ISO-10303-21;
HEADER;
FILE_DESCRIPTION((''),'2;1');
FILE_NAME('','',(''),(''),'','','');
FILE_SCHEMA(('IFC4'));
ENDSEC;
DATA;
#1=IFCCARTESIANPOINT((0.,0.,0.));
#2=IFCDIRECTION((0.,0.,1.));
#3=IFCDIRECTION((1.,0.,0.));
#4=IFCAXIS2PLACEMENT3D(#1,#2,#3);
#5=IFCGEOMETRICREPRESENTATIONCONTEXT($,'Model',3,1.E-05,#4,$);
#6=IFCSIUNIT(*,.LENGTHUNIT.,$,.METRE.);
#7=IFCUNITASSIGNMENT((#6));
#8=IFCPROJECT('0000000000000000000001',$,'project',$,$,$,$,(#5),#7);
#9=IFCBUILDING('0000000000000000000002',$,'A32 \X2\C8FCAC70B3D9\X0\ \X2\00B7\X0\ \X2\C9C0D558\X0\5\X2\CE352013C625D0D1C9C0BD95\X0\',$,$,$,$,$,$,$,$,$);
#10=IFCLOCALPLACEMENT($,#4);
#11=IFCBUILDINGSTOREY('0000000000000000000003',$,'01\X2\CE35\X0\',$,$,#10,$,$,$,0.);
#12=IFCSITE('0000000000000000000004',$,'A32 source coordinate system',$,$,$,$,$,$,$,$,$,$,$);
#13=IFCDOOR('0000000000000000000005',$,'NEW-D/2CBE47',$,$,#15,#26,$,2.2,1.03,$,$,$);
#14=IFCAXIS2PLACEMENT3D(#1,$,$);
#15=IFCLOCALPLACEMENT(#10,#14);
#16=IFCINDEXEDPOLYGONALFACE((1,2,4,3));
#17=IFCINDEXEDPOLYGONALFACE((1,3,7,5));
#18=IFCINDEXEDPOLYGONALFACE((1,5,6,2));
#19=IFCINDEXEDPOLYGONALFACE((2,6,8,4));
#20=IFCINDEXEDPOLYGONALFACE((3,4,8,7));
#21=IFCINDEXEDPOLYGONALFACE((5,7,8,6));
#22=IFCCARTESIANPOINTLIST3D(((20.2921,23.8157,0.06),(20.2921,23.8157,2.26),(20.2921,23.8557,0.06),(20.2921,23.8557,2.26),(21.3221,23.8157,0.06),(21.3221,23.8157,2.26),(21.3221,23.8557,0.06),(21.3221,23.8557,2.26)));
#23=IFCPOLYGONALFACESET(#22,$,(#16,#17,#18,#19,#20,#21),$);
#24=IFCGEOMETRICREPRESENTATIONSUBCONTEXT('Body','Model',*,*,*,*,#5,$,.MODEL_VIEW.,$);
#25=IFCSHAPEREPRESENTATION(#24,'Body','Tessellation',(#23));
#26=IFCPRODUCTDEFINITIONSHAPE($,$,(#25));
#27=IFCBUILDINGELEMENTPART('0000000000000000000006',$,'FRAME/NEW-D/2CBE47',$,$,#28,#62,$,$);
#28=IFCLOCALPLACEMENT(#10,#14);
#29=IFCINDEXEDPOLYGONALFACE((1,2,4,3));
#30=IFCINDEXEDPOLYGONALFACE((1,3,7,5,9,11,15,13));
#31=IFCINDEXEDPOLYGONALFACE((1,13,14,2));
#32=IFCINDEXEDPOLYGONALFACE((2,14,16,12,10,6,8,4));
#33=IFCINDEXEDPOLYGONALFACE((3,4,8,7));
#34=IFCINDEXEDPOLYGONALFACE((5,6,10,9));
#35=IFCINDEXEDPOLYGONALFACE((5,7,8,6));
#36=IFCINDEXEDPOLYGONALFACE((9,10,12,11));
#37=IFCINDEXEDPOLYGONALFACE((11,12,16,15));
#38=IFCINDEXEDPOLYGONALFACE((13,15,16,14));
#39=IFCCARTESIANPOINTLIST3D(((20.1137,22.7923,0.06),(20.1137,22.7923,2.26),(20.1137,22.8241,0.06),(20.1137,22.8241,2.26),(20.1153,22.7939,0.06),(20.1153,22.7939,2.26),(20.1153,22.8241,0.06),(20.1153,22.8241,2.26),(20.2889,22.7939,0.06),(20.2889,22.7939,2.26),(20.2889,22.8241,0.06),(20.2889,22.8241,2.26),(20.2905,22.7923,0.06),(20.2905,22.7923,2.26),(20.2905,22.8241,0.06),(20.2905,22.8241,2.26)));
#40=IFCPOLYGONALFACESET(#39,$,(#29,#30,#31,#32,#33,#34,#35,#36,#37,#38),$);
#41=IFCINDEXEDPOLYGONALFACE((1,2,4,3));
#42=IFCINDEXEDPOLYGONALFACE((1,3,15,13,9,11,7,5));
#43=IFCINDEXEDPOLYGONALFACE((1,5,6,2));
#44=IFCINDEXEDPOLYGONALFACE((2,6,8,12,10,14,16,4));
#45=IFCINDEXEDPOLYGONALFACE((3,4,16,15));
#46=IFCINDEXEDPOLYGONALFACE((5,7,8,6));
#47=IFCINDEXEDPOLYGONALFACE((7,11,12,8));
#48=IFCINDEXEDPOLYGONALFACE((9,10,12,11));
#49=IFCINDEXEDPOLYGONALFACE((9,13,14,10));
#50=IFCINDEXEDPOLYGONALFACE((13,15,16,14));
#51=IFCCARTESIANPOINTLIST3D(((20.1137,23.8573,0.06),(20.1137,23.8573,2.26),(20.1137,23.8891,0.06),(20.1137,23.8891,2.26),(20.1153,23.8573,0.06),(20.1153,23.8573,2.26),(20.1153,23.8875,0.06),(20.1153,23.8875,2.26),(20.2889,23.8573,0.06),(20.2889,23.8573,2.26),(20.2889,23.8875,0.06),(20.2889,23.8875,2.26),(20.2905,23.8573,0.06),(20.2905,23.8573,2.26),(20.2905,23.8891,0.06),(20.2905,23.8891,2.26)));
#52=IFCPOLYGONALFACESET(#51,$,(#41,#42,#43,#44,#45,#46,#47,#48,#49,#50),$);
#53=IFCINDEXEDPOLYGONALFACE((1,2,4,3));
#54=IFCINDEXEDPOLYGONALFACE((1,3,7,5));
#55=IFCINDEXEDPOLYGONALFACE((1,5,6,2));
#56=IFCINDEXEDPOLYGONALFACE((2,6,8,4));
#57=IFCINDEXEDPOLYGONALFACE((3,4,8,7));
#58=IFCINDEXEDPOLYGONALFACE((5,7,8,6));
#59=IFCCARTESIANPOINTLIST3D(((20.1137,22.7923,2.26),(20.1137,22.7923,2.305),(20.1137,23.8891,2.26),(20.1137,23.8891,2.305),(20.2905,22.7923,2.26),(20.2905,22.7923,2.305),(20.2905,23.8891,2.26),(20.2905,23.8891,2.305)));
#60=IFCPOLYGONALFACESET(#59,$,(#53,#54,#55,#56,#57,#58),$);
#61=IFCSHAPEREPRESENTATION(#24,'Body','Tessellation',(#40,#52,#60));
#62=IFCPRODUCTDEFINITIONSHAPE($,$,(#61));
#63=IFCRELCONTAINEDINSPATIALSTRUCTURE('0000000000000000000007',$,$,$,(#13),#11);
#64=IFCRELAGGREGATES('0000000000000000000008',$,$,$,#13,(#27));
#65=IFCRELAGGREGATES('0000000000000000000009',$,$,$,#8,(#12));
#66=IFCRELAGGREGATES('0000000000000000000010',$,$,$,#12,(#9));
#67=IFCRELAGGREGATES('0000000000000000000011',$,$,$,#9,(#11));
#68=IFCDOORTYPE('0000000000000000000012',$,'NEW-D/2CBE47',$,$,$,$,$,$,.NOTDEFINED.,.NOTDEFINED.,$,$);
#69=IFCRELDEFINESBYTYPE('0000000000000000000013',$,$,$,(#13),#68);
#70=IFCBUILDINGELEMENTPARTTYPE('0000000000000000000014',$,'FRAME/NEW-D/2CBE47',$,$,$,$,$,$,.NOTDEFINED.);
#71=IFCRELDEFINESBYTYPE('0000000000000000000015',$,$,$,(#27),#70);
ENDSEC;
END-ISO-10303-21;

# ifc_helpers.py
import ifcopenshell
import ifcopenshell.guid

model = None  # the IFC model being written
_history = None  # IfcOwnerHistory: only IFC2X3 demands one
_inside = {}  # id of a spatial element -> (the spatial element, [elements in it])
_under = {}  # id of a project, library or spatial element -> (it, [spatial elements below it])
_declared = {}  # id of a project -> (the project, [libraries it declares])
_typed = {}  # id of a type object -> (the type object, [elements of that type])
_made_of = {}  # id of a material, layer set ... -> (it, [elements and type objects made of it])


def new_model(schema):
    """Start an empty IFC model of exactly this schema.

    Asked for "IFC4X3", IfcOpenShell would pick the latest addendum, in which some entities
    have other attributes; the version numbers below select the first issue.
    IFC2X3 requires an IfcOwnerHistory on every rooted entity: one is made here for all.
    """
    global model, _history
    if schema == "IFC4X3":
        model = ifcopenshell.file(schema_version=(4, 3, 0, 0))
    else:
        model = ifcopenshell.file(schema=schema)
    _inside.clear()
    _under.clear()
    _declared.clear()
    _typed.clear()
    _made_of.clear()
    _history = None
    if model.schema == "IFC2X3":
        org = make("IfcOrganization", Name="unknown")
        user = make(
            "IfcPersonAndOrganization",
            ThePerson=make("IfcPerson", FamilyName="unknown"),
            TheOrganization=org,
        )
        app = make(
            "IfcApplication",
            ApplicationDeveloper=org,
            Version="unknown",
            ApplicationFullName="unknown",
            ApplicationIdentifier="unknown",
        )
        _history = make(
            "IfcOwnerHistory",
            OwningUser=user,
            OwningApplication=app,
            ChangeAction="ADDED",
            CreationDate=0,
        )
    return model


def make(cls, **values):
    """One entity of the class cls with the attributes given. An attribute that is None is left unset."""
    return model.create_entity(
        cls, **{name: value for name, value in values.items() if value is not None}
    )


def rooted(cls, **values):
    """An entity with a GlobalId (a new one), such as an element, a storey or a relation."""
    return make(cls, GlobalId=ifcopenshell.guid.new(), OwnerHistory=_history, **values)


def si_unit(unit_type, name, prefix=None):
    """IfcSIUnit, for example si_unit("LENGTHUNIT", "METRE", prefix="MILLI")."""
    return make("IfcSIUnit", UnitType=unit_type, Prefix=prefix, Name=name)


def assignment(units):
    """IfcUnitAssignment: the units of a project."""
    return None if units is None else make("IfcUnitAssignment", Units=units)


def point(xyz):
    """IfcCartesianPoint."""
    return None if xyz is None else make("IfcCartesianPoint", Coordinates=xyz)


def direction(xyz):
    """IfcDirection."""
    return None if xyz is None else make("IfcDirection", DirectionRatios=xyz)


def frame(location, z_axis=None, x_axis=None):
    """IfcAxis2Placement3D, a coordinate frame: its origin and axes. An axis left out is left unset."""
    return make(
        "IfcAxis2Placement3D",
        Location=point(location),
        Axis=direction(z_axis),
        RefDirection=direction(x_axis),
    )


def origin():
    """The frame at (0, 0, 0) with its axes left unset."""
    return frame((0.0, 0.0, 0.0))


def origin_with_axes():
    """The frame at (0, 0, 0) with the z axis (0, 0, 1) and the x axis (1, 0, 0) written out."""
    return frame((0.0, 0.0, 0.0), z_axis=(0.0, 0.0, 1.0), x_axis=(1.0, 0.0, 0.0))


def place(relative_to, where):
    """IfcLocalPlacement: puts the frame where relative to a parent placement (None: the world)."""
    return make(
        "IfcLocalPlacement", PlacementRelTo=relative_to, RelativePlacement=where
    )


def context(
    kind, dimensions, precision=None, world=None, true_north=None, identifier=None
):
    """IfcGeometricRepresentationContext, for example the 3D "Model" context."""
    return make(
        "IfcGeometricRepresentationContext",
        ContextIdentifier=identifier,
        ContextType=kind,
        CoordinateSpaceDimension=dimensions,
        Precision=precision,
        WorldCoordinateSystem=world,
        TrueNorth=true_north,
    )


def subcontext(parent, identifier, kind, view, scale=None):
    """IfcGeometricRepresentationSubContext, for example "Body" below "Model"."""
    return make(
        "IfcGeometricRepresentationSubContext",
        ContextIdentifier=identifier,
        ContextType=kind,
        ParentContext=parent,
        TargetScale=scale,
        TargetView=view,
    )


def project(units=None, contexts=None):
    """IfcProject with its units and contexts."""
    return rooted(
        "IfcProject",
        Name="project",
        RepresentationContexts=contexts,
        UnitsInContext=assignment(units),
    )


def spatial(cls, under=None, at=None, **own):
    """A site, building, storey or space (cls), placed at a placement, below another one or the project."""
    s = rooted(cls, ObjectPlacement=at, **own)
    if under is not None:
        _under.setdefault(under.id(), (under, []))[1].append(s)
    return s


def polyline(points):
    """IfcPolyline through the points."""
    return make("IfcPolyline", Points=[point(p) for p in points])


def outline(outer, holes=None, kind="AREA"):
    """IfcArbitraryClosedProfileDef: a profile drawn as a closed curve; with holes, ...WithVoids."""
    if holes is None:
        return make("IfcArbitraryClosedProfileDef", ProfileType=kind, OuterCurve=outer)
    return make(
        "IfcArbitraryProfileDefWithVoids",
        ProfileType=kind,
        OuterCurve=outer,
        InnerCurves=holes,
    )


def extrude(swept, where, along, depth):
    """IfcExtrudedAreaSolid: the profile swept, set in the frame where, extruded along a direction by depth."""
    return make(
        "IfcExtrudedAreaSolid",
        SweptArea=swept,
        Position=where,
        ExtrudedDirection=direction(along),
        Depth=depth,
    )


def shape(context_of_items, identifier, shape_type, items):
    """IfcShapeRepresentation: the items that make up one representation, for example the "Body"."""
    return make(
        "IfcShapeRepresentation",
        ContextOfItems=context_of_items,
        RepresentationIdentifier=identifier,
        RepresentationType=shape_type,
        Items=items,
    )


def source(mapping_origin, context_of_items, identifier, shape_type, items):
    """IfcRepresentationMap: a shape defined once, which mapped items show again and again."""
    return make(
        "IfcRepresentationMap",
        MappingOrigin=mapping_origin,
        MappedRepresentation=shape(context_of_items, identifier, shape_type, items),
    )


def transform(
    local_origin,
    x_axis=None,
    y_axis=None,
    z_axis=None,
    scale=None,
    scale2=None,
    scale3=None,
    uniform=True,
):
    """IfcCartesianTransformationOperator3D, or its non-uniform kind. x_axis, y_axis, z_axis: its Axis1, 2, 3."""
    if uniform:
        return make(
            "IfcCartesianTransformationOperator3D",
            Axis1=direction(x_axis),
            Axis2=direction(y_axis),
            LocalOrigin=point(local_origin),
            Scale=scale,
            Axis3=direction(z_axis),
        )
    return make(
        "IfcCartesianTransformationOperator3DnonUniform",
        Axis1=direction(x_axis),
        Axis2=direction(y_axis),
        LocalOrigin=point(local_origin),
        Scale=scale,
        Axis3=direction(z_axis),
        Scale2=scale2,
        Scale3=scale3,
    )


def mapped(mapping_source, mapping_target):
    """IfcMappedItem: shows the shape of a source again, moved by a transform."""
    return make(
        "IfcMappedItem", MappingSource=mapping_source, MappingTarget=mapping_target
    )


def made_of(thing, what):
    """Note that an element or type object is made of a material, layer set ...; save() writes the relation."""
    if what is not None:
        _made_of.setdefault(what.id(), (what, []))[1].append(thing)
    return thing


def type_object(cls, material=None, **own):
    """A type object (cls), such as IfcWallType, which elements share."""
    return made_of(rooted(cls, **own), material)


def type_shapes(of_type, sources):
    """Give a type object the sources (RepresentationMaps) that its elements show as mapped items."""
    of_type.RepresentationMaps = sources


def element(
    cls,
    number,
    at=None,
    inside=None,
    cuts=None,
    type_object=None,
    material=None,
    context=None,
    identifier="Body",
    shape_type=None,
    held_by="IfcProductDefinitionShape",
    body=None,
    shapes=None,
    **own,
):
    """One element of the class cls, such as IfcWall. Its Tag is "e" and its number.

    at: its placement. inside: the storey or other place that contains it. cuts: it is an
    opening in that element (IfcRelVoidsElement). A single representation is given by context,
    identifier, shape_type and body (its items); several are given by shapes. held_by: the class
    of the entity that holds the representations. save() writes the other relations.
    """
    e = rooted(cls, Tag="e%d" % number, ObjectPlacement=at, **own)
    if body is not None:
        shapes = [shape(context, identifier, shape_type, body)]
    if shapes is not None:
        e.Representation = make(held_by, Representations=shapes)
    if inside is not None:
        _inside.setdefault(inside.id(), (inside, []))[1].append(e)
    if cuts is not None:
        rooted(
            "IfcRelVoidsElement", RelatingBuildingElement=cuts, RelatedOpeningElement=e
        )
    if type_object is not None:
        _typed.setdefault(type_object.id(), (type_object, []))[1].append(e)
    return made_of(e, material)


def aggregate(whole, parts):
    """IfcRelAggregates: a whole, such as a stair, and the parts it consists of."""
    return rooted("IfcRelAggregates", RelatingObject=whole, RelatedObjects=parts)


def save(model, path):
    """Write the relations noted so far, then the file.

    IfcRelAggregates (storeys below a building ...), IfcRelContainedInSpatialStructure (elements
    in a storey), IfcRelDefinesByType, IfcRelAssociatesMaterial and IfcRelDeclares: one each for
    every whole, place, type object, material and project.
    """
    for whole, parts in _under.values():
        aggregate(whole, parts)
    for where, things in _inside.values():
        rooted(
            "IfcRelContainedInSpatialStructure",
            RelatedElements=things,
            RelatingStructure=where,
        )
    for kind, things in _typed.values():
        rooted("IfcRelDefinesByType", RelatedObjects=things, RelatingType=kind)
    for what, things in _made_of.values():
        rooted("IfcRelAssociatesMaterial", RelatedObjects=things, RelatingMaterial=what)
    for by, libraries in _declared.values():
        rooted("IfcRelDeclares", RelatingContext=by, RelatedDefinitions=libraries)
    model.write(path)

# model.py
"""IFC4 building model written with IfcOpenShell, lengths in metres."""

from ifc_helpers import new_model, si_unit, frame, origin, origin_with_axes, place, context, subcontext, project, spatial, polyline, outline, extrude, source, transform, mapped, type_object, type_shapes, element, aggregate, save


model = new_model("IFC4")

# Units and contexts
model_context = context("Model", 3, precision=1e-05, world=origin_with_axes())
body_context = subcontext(model_context, "Body", "Model", "MODEL_VIEW")
ifc_project = project(units=[si_unit("LENGTHUNIT", "METRE")], contexts=[model_context])

# Site, building, storey
site = spatial("IfcSite", under=ifc_project, Name="A32 source coordinate system")
building = spatial("IfcBuilding", under=site, Name="A32 주거동 · 지하5층–옥탑지붕")
storey_placement = place(None, origin_with_axes())
storey = spatial("IfcBuildingStorey", under=building, at=storey_placement, Name="01층", Elevation=0.0)

# Door
door_type_1 = type_object("IfcDoorType", Name="NEW-D/2CBE47", OperationType="NOTDEFINED", PredefinedType="NOTDEFINED")
shared_shape_1 = source(origin(), body_context, "Body", "SweptSolid", [
    extrude(outline(polyline([(21.3221, 23.8157), (20.2921, 23.8157), (20.2921, 23.8557), (21.3221, 23.8557), (21.3221, 23.8157)])), frame((0.0, 0.0, 0.06)), (0.0, 0.0, 1.0), 2.2),
])
type_shapes(door_type_1, [shared_shape_1])
door_1_placement = place(storey_placement, origin_with_axes())
door_1 = element("IfcDoor", 1, at=door_1_placement, inside=storey, type_object=door_type_1, Name="NEW-D/2CBE47", OverallHeight=2.2, OverallWidth=1.03, context=body_context, shape_type="MappedRepresentation", body=[
    mapped(shared_shape_1, transform((0.0, 0.0, 0.0), scale=1.0)),
])

# Building element part
building_element_part_type_1 = type_object("IfcBuildingElementPartType", Name="FRAME/NEW-D/2CBE47", PredefinedType="NOTDEFINED")
shared_shape_2 = source(origin(), body_context, "Body", "SweptSolid", [
    extrude(outline(polyline([(20.1137, 22.7923), (20.1137, 22.8241), (20.1153, 22.8241), (20.1153, 22.7939), (20.2889, 22.7939), (20.2889, 22.8241), (20.2905, 22.8241), (20.2905, 22.7923), (20.1137, 22.7923)])), frame((0.0, 0.0, 0.06)), (0.0, 0.0, 1.0), 2.2),
    extrude(outline(polyline([(20.2889, 23.8875), (20.1153, 23.8875), (20.1153, 23.8573), (20.1137, 23.8573), (20.1137, 23.8891), (20.2905, 23.8891), (20.2905, 23.8573), (20.2889, 23.8573), (20.2889, 23.8875)])), frame((0.0, 0.0, 0.06)), (0.0, 0.0, 1.0), 2.2),
    extrude(outline(polyline([(20.2905, 22.7923), (20.2905, 23.8891), (20.1137, 23.8891), (20.1137, 22.7923), (20.2905, 22.7923)])), frame((0.0, 0.0, 2.26)), (0.0, 0.0, 1.0), 0.045),
])
type_shapes(building_element_part_type_1, [shared_shape_2])
building_element_part_1_placement = place(door_1_placement, origin_with_axes())
building_element_part_1 = element("IfcBuildingElementPart", 2, at=building_element_part_1_placement, type_object=building_element_part_type_1, Name="FRAME/NEW-D/2CBE47", context=body_context, shape_type="MappedRepresentation", body=[
    mapped(shared_shape_2, transform((0.0, 0.0, 0.0), scale=1.0)),
])
aggregate(door_1, [building_element_part_1])

save(model, "model.ifc")
